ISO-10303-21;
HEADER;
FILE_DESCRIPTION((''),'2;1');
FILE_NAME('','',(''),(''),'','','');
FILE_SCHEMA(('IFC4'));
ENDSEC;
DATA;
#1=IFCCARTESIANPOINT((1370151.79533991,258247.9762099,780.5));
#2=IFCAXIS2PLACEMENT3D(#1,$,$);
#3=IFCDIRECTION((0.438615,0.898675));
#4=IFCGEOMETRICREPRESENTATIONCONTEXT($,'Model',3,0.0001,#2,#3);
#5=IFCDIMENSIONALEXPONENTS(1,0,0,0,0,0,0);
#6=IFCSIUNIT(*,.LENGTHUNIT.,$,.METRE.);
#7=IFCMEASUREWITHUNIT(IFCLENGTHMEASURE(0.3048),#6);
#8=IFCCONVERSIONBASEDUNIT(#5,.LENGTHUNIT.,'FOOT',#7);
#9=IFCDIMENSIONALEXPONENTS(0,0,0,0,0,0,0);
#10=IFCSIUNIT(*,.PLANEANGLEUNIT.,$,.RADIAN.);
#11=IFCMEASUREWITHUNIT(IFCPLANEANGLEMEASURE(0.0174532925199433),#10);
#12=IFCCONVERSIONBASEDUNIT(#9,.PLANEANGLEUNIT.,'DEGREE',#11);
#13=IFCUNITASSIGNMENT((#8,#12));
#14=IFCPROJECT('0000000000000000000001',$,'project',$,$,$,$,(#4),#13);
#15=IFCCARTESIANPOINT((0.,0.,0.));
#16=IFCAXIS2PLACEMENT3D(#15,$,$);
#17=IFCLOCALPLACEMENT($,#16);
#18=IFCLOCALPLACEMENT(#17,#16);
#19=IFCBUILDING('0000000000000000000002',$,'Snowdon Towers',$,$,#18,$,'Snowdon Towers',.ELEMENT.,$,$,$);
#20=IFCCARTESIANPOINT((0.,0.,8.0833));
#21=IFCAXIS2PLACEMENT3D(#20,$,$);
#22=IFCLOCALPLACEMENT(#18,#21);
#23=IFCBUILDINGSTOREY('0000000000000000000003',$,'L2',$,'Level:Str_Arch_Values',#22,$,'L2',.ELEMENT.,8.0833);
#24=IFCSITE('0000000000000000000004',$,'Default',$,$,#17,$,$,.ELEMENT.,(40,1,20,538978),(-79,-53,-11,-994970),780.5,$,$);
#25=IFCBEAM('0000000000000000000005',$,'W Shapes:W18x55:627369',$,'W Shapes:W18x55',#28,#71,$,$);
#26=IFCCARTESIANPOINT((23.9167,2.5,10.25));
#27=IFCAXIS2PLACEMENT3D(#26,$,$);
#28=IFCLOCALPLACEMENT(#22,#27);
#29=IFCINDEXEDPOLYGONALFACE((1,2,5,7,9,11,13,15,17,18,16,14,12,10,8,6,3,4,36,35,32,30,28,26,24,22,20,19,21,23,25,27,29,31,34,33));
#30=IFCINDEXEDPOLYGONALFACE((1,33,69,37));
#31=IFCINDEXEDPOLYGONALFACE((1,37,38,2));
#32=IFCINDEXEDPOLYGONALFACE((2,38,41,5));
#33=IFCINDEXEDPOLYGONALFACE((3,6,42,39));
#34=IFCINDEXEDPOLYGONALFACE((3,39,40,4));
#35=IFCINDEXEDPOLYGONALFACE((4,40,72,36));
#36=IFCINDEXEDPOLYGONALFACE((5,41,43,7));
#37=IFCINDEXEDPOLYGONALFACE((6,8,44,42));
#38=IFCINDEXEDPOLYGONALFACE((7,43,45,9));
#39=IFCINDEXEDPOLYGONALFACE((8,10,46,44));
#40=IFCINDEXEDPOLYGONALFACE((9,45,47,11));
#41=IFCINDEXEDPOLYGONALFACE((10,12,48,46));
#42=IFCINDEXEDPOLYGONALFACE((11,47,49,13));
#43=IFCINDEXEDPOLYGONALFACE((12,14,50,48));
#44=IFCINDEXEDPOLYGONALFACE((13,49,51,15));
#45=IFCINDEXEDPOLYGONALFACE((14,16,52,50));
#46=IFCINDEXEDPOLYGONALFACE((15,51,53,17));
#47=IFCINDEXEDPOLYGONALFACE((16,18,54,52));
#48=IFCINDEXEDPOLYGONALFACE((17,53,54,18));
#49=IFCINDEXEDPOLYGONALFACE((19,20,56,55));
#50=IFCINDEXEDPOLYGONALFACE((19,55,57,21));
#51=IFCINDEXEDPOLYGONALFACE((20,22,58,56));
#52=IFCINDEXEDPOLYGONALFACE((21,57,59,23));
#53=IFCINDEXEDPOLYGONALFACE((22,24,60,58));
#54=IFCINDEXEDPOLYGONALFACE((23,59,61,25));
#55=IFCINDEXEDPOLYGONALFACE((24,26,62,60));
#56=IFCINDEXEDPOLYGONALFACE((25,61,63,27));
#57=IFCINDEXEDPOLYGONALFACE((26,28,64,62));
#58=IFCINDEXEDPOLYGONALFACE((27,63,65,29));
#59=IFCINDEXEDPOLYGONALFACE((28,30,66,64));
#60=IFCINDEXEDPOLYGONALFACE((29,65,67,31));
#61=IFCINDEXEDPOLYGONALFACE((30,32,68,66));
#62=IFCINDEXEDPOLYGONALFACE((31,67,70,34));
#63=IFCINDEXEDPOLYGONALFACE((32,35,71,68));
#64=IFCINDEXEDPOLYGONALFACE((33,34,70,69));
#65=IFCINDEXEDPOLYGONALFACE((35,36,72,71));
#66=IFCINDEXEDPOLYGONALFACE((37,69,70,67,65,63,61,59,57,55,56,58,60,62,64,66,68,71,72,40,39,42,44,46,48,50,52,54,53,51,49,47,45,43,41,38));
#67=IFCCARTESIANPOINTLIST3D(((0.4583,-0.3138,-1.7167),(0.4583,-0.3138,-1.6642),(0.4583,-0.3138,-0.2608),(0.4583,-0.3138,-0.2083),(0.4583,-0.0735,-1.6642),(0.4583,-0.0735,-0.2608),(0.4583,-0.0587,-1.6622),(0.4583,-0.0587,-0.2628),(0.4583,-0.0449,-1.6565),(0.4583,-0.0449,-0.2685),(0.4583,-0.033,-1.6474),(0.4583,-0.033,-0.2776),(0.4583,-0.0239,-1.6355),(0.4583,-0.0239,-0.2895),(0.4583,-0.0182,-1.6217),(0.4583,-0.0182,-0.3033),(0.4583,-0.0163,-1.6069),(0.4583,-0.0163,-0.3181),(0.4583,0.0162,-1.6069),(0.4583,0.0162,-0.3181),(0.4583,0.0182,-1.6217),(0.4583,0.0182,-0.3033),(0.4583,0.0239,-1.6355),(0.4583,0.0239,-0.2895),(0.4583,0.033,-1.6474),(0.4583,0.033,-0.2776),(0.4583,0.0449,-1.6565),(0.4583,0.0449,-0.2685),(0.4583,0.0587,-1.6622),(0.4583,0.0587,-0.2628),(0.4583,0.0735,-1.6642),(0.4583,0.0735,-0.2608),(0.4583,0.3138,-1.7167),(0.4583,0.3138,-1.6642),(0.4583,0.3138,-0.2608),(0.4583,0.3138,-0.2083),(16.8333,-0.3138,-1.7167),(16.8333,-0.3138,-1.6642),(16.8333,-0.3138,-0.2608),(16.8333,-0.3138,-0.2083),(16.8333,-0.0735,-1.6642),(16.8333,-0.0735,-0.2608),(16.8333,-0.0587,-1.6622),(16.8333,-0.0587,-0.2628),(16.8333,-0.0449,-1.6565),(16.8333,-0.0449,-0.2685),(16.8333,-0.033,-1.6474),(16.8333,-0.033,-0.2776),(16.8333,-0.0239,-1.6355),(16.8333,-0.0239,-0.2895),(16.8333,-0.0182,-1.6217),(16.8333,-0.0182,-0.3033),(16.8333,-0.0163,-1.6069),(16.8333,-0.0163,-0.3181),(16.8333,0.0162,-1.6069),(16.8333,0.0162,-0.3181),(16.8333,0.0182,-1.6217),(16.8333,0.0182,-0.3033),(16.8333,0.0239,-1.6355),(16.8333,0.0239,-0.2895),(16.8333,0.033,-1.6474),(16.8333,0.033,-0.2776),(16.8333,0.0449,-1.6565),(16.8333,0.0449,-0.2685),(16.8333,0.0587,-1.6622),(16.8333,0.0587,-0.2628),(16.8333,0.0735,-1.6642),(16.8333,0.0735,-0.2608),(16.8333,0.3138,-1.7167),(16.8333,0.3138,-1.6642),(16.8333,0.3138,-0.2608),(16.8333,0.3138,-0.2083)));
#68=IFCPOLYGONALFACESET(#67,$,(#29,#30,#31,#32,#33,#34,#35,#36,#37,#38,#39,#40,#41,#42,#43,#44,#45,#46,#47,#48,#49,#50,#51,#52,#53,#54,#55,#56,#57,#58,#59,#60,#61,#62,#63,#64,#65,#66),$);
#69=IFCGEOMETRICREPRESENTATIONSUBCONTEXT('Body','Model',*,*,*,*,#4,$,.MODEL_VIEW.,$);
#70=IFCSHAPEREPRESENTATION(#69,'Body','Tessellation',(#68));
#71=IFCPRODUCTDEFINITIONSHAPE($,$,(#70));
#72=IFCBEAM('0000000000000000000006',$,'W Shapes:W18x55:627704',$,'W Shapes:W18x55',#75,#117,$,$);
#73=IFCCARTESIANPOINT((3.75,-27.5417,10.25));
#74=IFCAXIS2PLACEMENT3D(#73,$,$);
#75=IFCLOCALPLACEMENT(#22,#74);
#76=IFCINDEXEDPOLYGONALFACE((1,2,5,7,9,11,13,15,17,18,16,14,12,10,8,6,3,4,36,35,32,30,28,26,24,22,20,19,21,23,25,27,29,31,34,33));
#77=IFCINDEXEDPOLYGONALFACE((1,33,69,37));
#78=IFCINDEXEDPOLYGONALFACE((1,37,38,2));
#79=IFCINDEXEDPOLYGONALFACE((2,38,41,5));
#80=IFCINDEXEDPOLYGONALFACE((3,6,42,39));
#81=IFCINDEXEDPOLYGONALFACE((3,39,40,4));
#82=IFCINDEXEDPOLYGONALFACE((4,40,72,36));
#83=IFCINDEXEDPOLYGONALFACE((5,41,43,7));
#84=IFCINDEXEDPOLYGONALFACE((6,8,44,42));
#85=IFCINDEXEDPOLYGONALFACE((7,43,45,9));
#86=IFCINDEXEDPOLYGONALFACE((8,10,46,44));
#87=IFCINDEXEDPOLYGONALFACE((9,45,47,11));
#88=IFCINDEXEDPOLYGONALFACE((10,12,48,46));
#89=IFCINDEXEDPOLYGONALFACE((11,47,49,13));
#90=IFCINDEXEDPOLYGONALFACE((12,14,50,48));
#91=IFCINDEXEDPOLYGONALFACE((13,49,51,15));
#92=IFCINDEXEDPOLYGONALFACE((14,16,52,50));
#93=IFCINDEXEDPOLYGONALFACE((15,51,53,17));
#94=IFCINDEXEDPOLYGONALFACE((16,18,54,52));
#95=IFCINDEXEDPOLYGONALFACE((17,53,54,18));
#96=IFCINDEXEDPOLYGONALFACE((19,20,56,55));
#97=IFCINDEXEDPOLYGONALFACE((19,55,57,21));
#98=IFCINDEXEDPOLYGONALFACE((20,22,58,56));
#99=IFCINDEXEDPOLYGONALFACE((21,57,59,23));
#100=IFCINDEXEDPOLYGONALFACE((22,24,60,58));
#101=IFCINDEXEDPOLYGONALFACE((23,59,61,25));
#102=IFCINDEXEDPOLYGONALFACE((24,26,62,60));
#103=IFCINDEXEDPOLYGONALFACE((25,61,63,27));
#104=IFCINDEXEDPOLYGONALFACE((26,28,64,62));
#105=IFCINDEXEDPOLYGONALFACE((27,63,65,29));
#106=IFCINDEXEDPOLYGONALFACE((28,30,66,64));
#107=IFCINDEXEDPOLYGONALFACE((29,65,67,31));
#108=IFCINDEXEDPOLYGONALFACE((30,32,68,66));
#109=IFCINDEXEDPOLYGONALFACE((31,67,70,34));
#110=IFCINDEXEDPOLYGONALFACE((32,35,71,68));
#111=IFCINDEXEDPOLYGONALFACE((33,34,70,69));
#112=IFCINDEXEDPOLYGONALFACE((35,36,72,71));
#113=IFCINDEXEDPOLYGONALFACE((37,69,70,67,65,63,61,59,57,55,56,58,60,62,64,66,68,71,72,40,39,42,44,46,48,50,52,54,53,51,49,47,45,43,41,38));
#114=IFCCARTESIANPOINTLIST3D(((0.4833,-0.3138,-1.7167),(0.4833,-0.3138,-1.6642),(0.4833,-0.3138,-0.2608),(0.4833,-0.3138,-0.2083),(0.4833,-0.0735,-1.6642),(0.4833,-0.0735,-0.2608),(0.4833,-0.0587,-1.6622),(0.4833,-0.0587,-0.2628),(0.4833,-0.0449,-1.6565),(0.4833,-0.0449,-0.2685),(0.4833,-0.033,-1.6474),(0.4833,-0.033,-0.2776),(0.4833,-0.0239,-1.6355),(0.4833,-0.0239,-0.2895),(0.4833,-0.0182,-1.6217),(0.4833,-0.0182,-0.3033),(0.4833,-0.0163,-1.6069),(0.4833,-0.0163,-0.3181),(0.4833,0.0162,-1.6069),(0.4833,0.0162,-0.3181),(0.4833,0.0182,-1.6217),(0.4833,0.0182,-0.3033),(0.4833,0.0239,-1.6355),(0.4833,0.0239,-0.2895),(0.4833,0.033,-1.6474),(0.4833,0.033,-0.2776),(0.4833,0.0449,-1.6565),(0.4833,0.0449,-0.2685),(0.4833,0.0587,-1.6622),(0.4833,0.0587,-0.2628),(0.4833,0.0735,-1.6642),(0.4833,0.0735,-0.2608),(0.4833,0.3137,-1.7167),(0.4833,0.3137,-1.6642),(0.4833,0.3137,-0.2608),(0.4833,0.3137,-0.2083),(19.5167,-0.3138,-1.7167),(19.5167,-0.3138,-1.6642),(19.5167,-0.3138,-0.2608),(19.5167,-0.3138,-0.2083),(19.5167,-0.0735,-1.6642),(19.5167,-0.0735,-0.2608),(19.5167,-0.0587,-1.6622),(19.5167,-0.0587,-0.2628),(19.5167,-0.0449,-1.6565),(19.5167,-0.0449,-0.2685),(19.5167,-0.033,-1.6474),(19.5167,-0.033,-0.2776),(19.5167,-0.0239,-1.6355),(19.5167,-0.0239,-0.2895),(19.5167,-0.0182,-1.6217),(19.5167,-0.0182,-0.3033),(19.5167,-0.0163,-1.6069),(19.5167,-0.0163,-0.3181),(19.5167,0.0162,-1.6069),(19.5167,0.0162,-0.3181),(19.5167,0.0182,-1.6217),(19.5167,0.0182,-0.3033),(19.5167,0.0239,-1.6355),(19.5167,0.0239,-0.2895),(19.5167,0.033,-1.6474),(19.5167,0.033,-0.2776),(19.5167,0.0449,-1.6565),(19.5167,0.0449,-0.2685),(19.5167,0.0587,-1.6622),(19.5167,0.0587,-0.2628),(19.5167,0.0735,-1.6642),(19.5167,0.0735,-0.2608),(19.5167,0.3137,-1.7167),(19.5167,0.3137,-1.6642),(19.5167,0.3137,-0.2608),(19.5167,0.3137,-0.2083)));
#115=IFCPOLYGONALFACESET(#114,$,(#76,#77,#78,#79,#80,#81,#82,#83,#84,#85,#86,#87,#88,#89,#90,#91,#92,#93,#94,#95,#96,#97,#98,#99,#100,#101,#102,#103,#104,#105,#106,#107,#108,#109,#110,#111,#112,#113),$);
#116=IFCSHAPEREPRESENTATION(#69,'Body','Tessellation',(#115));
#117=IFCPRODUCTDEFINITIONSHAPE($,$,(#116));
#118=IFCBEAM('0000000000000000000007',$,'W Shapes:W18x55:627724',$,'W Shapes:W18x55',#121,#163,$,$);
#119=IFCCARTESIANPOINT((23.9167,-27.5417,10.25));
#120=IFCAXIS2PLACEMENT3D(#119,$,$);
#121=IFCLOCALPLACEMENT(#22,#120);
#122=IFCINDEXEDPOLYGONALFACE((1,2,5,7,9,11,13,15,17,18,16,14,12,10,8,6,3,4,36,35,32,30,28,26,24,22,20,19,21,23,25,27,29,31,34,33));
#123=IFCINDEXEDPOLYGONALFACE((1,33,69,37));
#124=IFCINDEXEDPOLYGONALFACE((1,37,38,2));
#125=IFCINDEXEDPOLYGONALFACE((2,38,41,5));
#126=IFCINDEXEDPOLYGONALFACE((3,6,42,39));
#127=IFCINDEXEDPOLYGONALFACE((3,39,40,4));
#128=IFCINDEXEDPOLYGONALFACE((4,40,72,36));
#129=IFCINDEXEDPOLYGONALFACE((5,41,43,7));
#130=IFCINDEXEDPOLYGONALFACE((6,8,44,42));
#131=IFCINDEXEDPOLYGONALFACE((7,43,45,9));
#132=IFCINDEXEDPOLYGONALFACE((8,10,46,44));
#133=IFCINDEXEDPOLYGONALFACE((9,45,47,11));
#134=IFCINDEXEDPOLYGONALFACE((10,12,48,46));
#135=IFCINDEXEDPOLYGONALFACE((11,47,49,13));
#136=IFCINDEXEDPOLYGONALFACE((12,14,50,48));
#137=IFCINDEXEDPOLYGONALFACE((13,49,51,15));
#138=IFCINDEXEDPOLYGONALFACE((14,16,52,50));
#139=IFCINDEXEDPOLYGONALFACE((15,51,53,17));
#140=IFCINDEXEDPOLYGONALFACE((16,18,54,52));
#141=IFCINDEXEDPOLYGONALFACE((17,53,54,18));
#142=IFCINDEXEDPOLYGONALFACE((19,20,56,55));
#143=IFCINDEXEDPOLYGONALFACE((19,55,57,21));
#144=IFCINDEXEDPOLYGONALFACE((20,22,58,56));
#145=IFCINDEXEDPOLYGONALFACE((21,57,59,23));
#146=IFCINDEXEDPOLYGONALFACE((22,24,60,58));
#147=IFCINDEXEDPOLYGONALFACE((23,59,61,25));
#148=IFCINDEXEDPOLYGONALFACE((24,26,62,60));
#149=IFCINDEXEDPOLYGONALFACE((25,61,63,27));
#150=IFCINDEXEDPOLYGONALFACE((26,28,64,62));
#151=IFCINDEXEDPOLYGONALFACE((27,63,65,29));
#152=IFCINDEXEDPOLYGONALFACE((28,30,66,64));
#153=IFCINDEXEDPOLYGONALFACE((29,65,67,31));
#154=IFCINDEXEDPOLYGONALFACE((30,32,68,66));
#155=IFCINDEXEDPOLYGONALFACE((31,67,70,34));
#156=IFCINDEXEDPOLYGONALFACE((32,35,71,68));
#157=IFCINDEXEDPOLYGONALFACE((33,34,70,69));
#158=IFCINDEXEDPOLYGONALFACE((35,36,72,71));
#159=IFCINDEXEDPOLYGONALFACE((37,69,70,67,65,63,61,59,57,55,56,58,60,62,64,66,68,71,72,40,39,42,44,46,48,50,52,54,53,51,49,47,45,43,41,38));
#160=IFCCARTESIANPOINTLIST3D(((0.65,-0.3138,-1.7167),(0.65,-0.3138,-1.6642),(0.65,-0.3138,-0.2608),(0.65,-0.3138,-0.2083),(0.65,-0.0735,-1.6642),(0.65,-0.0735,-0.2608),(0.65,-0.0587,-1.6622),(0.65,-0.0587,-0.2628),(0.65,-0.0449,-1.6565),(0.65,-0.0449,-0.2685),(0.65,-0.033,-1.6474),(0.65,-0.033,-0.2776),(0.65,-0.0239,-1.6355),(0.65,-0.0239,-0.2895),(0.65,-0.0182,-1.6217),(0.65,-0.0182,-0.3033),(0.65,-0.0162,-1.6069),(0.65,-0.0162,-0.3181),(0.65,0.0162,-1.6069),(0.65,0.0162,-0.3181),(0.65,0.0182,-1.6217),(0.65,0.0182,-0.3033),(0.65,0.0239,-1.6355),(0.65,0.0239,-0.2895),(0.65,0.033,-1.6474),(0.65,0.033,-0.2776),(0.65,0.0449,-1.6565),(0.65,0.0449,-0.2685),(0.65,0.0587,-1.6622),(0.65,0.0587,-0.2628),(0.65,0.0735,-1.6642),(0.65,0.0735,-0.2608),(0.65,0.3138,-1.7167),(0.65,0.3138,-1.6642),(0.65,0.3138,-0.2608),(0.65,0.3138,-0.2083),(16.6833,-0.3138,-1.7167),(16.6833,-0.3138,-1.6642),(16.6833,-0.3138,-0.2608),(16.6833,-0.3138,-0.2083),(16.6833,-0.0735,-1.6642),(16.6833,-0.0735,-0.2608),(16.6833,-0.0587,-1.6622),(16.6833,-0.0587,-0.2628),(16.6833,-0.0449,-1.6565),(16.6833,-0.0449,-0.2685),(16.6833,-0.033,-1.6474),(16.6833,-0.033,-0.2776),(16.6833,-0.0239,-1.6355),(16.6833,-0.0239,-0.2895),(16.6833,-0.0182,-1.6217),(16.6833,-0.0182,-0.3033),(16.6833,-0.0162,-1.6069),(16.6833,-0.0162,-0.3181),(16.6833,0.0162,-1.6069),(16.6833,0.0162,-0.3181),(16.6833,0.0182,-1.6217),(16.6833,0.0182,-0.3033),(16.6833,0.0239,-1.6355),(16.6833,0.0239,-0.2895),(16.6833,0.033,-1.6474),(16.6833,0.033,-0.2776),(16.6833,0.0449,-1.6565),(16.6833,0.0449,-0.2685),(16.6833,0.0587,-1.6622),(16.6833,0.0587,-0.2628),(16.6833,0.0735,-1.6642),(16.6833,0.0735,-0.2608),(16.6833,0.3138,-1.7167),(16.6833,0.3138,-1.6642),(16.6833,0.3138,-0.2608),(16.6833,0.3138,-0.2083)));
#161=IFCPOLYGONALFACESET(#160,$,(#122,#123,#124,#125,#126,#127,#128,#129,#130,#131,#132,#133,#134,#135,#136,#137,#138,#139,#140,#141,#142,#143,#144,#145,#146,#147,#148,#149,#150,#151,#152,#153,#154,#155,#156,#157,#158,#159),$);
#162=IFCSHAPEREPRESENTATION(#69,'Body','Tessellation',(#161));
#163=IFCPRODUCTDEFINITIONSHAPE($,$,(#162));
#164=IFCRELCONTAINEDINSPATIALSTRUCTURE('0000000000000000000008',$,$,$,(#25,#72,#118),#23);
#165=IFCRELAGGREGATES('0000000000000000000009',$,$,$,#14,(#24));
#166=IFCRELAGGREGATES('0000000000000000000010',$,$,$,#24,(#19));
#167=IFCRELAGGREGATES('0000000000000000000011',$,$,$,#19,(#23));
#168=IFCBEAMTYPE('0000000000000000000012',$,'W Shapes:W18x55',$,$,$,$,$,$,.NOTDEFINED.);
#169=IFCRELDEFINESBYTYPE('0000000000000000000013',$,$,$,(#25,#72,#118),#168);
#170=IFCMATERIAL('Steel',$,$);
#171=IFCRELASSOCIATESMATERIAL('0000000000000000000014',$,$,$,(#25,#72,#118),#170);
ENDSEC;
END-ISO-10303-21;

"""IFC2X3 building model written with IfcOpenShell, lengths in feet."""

from ifc_helpers import new_model, entity, si_unit, converted_unit, direction, frame, frame_2d, origin, place, context, subcontext, project, spatial, i_section, extrude, material, type_object, element, save


model = new_model("IFC2X3")

# Units and contexts
model_context = context("Model", 3, precision=0.0001, world=frame((1370151.79533991, 258247.9762099, 780.5)), true_north=direction((0.438615, 0.898675)))
body_context = subcontext(model_context, "Body", "Model", "MODEL_VIEW")
ifc_project = project(units=[converted_unit("LENGTHUNIT", "FOOT", entity("IfcLengthMeasure", 0.3048), si_unit("LENGTHUNIT", "METRE"), dimensions=[1, 0, 0, 0, 0, 0, 0]), converted_unit("PLANEANGLEUNIT", "DEGREE", entity("IfcPlaneAngleMeasure", 0.0174532925199433), si_unit("PLANEANGLEUNIT", "RADIAN"), dimensions=[0, 0, 0, 0, 0, 0, 0])], contexts=[model_context])

# Site, building, storey
site_placement = place(None, origin())
site = spatial("IfcSite", under=ifc_project, at=site_placement, Name="Default", CompositionType="ELEMENT", RefLatitude=(40, 1, 20, 538978), RefLongitude=(-79, -53, -11, -994970), RefElevation=780.5)
building_placement = place(site_placement, origin())
building = spatial("IfcBuilding", under=site, at=building_placement, Name="Snowdon Towers", LongName="Snowdon Towers", CompositionType="ELEMENT")
storey_placement = place(building_placement, frame((0.0, 0.0, 8.0833)))
storey = spatial("IfcBuildingStorey", under=building, at=storey_placement, Name="L2", ObjectType="Level:Str_Arch_Values", LongName="L2", CompositionType="ELEMENT", Elevation=8.0833)

# Beams
ifc_material = material(Name="Steel")
beam_type_1 = type_object("IfcBeamType", Name="W Shapes:W18x55", PredefinedType="NOTDEFINED")
beam_1_placement = place(storey_placement, frame((23.9167, 2.5, 10.25)))
element("IfcBeam", 1, at=beam_1_placement, inside=storey, type_object=beam_type_1, material=ifc_material, Name="W Shapes:W18x55:627369", ObjectType="W Shapes:W18x55", context=body_context, shape_type="SweptSolid", body=[
    extrude(i_section(OverallWidth=0.6275, OverallDepth=1.5083, WebThickness=0.0325, FlangeThickness=0.0525, FilletRadius=0.0573, at=frame_2d((0.0, 0.0), x_axis=(0.0, 1.0))), frame((0.4583, 0.0, -0.9625), z_axis=(1.0, 0.0, 0.0), x_axis=(0.0, 0.0, -1.0)), (0.0, 0.0, 1.0), 16.375),
])
beam_2_placement = place(storey_placement, frame((3.75, -27.5417, 10.25)))
element("IfcBeam", 2, at=beam_2_placement, inside=storey, type_object=beam_type_1, material=ifc_material, Name="W Shapes:W18x55:627704", ObjectType="W Shapes:W18x55", context=body_context, shape_type="SweptSolid", body=[
    extrude(i_section(OverallWidth=0.6275, OverallDepth=1.5083, WebThickness=0.0325, FlangeThickness=0.0525, FilletRadius=0.0573, at=frame_2d((0.0, 0.0), x_axis=(0.0, 1.0))), frame((0.4833, 0.0, -0.9625), z_axis=(1.0, 0.0, 0.0), x_axis=(0.0, 0.0, -1.0)), (0.0, 0.0, 1.0), 19.0333),
])
beam_3_placement = place(storey_placement, frame((23.9167, -27.5417, 10.25)))
element("IfcBeam", 3, at=beam_3_placement, inside=storey, type_object=beam_type_1, material=ifc_material, Name="W Shapes:W18x55:627724", ObjectType="W Shapes:W18x55", context=body_context, shape_type="SweptSolid", body=[
    extrude(i_section(OverallWidth=0.6275, OverallDepth=1.5083, WebThickness=0.0325, FlangeThickness=0.0525, FilletRadius=0.0573, at=frame_2d((0.0, 0.0), x_axis=(0.0, 1.0))), frame((0.65, 0.0, -0.9625), z_axis=(1.0, 0.0, 0.0), x_axis=(0.0, 0.0, -1.0)), (0.0, 0.0, 1.0), 16.0333),
])

save(model, "model.ifc")
